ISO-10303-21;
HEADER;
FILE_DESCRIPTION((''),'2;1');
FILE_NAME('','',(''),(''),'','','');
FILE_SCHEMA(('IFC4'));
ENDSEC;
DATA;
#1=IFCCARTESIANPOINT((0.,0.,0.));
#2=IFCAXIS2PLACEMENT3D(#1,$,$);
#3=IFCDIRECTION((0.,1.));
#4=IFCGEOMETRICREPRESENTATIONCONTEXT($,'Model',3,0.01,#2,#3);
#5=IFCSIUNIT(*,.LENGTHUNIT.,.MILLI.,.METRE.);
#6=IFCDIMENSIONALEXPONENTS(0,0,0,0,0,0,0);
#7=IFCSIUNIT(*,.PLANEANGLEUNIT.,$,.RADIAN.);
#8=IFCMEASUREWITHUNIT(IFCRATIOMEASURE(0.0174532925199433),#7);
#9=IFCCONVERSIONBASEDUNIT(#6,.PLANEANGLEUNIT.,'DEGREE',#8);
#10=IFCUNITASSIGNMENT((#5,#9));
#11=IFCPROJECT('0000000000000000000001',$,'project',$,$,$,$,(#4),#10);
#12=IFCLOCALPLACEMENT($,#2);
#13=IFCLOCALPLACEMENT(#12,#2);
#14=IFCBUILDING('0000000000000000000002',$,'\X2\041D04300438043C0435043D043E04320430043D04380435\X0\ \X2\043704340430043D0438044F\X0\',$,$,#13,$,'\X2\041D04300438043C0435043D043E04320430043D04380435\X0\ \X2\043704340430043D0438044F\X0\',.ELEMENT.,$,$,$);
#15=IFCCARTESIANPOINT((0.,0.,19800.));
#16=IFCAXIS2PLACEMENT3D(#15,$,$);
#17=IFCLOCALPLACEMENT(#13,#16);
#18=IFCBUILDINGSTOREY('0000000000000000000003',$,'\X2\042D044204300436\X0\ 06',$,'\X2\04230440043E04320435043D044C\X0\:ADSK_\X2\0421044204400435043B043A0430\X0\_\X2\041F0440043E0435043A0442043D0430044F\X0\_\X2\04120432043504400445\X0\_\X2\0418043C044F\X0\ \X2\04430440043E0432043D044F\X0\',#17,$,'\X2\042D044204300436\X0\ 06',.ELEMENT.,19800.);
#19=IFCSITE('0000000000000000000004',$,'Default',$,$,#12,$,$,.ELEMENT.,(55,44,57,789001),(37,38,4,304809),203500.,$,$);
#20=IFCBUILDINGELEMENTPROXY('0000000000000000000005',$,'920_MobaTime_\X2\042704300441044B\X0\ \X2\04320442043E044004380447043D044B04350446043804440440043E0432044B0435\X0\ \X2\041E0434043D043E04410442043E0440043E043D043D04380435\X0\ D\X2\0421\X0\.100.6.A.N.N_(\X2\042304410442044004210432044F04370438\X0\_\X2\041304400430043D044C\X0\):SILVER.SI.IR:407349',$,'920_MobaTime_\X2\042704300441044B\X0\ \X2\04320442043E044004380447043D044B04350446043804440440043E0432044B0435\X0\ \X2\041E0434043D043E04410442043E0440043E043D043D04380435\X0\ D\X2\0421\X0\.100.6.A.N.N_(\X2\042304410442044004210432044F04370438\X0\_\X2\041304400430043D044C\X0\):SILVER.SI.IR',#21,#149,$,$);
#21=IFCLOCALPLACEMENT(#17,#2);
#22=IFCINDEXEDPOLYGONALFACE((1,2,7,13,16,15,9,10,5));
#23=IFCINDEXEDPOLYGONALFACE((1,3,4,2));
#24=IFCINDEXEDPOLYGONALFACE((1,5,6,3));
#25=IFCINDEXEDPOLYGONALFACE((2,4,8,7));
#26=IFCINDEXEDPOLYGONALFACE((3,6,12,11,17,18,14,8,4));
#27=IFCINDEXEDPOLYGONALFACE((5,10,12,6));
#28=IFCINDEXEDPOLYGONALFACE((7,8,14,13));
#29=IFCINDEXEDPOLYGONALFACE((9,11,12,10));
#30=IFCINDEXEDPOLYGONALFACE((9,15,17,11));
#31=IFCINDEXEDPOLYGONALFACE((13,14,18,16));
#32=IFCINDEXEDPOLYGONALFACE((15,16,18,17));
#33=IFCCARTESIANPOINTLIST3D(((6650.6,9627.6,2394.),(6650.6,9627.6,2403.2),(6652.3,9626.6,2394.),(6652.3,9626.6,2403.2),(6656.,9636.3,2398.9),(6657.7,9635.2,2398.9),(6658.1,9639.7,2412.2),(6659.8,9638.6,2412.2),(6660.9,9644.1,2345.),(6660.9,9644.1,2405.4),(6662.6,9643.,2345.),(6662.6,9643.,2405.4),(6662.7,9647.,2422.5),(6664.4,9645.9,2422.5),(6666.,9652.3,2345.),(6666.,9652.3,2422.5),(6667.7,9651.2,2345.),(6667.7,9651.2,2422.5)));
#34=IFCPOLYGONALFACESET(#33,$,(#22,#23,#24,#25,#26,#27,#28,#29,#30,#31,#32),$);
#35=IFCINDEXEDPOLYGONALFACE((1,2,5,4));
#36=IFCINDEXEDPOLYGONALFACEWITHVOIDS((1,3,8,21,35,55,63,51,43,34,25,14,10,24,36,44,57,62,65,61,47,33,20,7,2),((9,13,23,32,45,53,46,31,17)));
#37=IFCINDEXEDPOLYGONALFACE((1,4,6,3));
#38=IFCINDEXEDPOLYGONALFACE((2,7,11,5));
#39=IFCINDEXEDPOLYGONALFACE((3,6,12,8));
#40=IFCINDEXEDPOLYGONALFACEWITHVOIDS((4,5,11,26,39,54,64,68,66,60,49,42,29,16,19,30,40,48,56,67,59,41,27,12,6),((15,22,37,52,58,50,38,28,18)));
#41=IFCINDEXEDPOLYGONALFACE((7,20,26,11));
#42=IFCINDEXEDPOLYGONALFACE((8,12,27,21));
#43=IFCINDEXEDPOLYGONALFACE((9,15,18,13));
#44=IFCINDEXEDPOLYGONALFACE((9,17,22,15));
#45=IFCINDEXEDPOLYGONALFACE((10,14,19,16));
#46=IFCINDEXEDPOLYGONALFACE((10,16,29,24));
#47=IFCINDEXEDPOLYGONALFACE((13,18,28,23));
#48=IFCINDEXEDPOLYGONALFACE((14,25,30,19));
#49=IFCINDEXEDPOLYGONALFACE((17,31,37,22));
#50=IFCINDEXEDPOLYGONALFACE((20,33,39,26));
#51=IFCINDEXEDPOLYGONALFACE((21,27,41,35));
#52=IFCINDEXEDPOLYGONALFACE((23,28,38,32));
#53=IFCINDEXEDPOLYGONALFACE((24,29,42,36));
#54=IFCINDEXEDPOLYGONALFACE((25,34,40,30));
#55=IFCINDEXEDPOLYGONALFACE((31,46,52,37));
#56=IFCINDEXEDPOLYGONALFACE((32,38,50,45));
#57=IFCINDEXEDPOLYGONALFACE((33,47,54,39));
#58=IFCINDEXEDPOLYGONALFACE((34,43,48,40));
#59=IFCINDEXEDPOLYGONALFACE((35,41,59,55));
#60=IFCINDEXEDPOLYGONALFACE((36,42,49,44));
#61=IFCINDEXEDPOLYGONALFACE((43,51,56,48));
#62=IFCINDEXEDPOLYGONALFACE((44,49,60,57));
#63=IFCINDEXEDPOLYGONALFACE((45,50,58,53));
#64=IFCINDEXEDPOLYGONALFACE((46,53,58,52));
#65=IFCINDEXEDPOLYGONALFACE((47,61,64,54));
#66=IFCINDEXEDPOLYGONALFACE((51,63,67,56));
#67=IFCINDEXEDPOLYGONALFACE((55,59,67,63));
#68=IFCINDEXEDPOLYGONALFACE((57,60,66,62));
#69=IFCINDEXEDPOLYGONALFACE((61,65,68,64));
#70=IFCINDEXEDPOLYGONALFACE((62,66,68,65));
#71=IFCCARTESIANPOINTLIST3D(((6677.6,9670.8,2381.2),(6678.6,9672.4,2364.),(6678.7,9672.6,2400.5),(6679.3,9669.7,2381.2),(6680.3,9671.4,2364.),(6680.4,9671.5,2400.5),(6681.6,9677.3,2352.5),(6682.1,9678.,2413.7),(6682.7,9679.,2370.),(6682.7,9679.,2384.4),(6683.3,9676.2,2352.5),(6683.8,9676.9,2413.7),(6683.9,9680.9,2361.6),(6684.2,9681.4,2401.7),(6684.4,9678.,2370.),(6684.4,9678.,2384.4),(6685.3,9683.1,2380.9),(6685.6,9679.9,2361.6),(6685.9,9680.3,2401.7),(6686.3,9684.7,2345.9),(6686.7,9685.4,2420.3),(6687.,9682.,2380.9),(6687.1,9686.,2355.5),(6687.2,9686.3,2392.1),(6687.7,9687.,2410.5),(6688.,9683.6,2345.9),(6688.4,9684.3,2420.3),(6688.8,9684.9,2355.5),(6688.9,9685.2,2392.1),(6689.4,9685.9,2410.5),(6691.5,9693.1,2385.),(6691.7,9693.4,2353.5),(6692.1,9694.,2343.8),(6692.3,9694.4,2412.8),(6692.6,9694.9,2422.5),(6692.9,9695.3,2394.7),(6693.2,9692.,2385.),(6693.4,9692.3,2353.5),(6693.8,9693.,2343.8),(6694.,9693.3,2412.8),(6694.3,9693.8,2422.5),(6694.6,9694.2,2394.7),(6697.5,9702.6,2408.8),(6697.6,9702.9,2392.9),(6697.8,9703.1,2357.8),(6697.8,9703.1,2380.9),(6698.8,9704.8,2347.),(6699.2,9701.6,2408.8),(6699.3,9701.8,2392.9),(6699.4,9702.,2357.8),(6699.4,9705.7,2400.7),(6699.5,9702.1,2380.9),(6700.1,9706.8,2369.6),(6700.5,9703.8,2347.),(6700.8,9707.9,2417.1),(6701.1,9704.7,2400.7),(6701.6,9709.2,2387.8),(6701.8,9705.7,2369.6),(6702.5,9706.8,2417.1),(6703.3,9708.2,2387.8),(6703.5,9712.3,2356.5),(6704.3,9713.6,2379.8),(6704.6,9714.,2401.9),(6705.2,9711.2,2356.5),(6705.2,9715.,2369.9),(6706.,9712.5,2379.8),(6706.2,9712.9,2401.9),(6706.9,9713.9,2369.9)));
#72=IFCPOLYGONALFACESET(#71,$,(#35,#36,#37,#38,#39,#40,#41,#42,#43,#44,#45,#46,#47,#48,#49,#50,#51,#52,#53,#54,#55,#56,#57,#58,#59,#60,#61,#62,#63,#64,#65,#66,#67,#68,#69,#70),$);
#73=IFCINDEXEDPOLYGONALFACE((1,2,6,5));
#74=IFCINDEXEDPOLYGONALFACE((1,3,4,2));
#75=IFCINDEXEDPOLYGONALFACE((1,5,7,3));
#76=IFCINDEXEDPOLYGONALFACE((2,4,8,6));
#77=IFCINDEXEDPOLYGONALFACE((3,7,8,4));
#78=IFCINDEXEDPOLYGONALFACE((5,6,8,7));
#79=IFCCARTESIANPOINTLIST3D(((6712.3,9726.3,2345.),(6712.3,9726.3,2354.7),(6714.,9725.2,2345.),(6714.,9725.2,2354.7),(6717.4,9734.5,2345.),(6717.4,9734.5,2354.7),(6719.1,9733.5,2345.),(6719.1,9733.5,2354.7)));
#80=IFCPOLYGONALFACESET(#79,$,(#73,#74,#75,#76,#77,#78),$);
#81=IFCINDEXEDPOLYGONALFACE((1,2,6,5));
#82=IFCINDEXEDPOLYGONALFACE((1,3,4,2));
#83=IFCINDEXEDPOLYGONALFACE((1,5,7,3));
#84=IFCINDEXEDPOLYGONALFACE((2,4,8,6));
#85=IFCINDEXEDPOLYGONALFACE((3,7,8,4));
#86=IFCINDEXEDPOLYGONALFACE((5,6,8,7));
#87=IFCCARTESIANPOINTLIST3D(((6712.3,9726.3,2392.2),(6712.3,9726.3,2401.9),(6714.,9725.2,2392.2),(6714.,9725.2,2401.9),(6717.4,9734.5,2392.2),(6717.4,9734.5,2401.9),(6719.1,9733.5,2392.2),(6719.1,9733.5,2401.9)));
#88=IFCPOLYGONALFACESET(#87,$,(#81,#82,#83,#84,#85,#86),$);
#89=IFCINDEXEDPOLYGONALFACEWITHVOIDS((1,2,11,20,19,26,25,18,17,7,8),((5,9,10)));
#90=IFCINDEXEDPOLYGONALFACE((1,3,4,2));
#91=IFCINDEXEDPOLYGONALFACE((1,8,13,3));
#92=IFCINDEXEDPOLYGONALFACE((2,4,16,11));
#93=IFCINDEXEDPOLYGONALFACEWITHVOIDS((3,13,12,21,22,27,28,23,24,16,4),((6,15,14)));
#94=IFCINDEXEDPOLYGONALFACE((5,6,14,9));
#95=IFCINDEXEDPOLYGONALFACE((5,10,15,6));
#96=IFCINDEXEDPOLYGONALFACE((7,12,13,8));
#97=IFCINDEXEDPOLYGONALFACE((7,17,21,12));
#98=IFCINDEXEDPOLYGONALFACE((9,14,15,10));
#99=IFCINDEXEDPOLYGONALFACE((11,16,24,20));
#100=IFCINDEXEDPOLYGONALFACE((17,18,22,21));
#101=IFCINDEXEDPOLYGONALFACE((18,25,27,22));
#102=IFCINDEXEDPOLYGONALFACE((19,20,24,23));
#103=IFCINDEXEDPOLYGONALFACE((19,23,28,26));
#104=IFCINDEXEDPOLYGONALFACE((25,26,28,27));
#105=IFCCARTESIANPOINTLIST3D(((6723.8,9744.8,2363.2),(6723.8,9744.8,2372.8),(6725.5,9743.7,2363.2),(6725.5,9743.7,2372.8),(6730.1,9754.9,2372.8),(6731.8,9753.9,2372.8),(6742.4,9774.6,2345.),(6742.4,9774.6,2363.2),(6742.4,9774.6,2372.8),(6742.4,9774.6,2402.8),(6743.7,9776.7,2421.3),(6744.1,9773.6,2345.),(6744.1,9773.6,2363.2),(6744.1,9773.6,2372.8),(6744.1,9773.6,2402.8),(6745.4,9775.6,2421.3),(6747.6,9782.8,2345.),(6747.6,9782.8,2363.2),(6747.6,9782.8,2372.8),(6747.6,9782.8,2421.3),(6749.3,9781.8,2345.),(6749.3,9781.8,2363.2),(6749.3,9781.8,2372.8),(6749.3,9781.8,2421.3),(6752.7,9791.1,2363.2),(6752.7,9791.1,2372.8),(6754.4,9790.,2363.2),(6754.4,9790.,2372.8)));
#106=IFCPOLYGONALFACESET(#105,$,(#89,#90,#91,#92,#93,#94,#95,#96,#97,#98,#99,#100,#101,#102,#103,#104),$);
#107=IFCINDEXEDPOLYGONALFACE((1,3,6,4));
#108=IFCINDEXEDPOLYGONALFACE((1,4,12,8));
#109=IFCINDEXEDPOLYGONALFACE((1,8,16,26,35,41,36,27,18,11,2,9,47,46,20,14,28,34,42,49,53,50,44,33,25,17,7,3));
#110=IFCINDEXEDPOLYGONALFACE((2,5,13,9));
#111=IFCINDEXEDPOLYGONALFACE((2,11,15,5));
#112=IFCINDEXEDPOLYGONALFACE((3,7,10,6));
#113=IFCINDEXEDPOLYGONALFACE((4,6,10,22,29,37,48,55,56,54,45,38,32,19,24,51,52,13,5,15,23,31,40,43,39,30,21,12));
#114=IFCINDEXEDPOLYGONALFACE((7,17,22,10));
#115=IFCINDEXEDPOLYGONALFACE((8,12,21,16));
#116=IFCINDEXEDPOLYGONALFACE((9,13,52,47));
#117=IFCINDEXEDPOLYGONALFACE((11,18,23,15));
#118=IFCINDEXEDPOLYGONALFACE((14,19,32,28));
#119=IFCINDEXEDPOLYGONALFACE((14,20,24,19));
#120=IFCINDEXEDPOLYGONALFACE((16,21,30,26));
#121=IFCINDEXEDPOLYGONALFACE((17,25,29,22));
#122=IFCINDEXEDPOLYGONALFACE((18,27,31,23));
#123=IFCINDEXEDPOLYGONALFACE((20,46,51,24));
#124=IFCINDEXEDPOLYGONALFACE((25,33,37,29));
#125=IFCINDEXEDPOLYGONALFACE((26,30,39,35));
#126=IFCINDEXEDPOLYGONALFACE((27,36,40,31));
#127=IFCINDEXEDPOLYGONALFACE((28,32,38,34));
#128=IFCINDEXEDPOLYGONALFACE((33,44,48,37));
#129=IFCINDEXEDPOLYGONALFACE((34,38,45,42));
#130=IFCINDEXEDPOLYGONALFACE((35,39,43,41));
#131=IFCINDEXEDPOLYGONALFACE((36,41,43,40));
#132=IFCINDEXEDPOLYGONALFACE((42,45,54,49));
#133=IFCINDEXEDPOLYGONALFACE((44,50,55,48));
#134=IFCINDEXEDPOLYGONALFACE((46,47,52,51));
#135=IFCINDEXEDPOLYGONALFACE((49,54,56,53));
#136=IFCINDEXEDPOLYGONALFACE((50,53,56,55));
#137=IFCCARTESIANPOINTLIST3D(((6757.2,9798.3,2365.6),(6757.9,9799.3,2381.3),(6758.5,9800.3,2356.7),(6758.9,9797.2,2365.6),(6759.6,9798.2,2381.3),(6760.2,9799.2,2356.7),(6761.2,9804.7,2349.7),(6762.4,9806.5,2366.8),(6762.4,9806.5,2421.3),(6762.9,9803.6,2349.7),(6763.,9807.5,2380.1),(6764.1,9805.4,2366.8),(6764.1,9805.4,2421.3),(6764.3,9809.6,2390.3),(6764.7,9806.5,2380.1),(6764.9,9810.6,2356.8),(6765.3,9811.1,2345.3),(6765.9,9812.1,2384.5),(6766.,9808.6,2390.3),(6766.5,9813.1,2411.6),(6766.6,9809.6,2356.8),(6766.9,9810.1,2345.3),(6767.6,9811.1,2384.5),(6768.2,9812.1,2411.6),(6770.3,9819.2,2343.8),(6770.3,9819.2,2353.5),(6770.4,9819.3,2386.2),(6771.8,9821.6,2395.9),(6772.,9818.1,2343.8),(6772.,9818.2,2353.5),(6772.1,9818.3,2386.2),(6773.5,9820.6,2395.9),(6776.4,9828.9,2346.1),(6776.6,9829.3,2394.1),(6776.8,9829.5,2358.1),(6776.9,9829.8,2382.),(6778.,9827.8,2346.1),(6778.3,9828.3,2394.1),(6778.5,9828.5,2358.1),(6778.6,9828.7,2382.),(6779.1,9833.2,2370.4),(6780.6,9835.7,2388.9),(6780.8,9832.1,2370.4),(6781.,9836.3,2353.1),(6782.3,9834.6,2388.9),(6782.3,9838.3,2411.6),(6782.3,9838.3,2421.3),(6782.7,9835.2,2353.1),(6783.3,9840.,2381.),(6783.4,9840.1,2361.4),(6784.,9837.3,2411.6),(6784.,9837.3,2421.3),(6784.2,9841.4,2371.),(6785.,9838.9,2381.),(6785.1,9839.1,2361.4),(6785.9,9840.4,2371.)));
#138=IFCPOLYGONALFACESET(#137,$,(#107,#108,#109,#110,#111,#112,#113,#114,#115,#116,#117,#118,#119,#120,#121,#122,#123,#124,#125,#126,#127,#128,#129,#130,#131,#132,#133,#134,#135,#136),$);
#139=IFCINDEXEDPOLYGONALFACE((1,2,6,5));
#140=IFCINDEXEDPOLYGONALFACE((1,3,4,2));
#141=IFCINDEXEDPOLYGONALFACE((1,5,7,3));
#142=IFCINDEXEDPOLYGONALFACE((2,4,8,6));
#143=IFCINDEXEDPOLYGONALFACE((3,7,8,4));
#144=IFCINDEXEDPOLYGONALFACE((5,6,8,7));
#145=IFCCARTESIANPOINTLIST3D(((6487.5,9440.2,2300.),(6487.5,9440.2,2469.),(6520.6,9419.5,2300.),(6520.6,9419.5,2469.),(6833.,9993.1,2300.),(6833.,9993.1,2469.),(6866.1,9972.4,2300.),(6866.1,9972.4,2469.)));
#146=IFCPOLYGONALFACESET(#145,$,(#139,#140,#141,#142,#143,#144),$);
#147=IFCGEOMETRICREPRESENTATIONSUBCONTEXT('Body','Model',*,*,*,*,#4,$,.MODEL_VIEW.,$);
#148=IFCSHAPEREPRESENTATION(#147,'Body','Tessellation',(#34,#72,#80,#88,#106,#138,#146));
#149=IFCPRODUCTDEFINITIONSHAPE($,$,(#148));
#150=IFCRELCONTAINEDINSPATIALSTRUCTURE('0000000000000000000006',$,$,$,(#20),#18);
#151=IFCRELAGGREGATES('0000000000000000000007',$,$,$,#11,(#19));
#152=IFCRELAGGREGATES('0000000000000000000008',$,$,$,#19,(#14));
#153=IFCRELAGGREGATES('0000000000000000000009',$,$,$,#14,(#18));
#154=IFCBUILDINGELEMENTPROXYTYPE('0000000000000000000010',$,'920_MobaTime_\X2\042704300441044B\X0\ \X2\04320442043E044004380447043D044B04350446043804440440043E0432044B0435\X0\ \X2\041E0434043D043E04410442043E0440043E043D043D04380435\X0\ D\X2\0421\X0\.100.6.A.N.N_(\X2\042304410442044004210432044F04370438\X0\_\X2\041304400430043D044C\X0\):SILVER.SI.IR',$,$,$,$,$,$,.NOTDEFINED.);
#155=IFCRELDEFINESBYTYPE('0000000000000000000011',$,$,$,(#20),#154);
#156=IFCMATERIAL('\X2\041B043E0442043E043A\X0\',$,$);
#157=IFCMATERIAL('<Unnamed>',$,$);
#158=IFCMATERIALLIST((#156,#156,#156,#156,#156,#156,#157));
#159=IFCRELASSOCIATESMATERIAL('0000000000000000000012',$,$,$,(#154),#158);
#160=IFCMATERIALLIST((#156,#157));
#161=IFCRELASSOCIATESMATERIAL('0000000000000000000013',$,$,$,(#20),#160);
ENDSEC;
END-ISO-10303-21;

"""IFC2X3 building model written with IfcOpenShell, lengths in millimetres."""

from ifc_helpers import new_model, entity, si_unit, converted_unit, direction, frame, origin, origin_2d_with_axis, place, context, subcontext, project, spatial, polyline, rectangle, outline, extrude, source, transform, mapped, material, material_list, type_object, type_shapes, element, save


model = new_model("IFC2X3")

# Units and contexts
model_context = context("Model", 3, precision=0.01, world=origin(), true_north=direction((0.0, 1.0)))
body_context = subcontext(model_context, "Body", "Model", "MODEL_VIEW")
ifc_project = project(units=[si_unit("LENGTHUNIT", "METRE", prefix="MILLI"), converted_unit("PLANEANGLEUNIT", "DEGREE", entity("IfcRatioMeasure", 0.0174532925199433), si_unit("PLANEANGLEUNIT", "RADIAN"), dimensions=[0, 0, 0, 0, 0, 0, 0])], contexts=[model_context])

# Site, building, storey
site_placement = place(None, frame((0.0, 0.0, 0.0)))
site = spatial("IfcSite", under=ifc_project, at=site_placement, Name="Default", CompositionType="ELEMENT", RefLatitude=(55, 44, 57, 789001), RefLongitude=(37, 38, 4, 304809), RefElevation=203500.0)
building_placement = place(site_placement, origin())
building = spatial("IfcBuilding", under=site, at=building_placement, Name="Наименование здания", LongName="Наименование здания", CompositionType="ELEMENT")
storey_placement = place(building_placement, frame((0.0, 0.0, 19800.0)))
storey = spatial("IfcBuildingStorey", under=building, at=storey_placement, Name="Этаж 06", ObjectType="Уровень:ADSK_Стрелка_Проектная_Вверх_Имя уровня", LongName="Этаж 06", CompositionType="ELEMENT", Elevation=19800.0)

# Building element proxy
ifc_material_1 = material(Name="Лоток")
ifc_material_2 = material(Name="<Unnamed>")
ifc_material_list_1 = material_list([ifc_material_1, ifc_material_2])
ifc_material_list_2 = material_list([ifc_material_1, ifc_material_1, ifc_material_1, ifc_material_1, ifc_material_1, ifc_material_1, ifc_material_2])
building_element_proxy_type_1 = type_object("IfcBuildingElementProxyType", Name="920_MobaTime_Часы вторичныецифровые Односторонние DС.100.6.A.N.N_(УстрСвязи_Грань):SILVER.SI.IR", PredefinedType="NOTDEFINED", material=ifc_material_list_2)
shared_shape_1 = source(origin(), body_context, "Body", "SweptSolid", [
    extrude(outline(polyline([(-49.3, -13.1), (28.2, -13.1), (28.2, -6.8), (17.9, 1.8), (8.9, 16.0), (-0.3, 16.0), (4.6, 5.8), (11.1, -3.4), (-49.3, -3.4), (-49.3, -13.1)])), frame((-64.6, 9.8, 39.0), z_axis=(0.0, 0.0, 1.0), x_axis=(0.0, 1.0, 0.0)), (0.0, 0.0, 1.0), 2.0),
    extrude(outline(polyline([(2.2, -27.6), (19.0, -27.6), (30.5, -16.1), (33.3, -4.9), (31.0, 5.8), (21.8, 17.2), (5.2, 27.3), (-11.1, 33.0), (-24.0, 32.7), (-33.6, 27.6), (-40.3, 18.6), (-42.8, 5.7), (-38.0, -6.3), (-27.2, -15.0), (-17.5, -17.7), (-8.2, -16.4), (-0.3, -11.9), (5.1, -4.5), (7.3, 6.2), (4.0, 17.2), (18.5, 7.3), (23.6, -2.4), (22.0, -11.4), (14.2, -18.4), (5.3, -18.3), (2.2, -27.6)]), holes=[polyline([(-9.0, 23.3), (-1.3, 14.4), (-2.6, 2.0), (-11.4, -7.0), (-23.4, -6.1), (-32.2, 2.9), (-31.2, 15.1), (-25.6, 22.1), (-17.5, 24.9), (-9.0, 23.3)])]), frame((-2.7, 3.6, 39.0), z_axis=(0.0, 0.0, 1.0), x_axis=(-0.427649, 0.903945, 0.0)), (0.0, 0.0, 1.0), 2.0),
    extrude(rectangle(XDim=9.7, YDim=9.7, at=origin_2d_with_axis()), frame((40.6, -34.7, 39.0)), (0.0, 0.0, 1.0), 2.0),
    extrude(rectangle(XDim=9.7, YDim=9.7, at=origin_2d_with_axis()), frame((40.6, 12.6, 39.0)), (0.0, 0.0, 1.0), 2.0),
    extrude(outline(polyline([(-0.9, -28.1), (8.8, -28.1), (8.8, -9.9), (18.5, -9.9), (18.5, -0.2), (8.8, -0.2), (8.8, 48.3), (1.5, 48.3), (-36.0, -0.2), (-36.0, -9.9), (-0.9, -9.9), (-0.9, -28.1)]), holes=[polyline([(-0.9, -0.2), (-24.1, -0.2), (-0.9, 29.7), (-0.9, -0.2)])]), frame((93.6, -11.4, 39.0)), (0.0, 0.0, 1.0), 2.0),
    extrude(outline(polyline([(3.3, -28.3), (12.5, -28.3), (20.5, -25.0), (26.8, -18.8), (30.7, -10.0), (31.4, 1.6), (26.9, 11.8), (20.1, 18.4), (11.1, 22.3), (1.0, 23.3), (-7.9, 20.4), (-14.9, 14.5), (-18.9, 6.2), (-17.1, -9.0), (-36.7, 0.5), (-29.1, 29.3), (-38.5, 31.7), (-48.1, -4.6), (-11.6, -23.0), (-8.0, -14.0), (-10.8, -7.6), (-10.2, 1.1), (-3.0, 11.8), (9.2, 12.8), (20.0, 5.4), (21.3, -7.5), (15.5, -16.4), (4.6, -18.6), (3.3, -28.3)])), frame((147.1, -8.5, 39.0), z_axis=(0.0, 0.0, 1.0), x_axis=(0.256974, -0.966418, 0.0)), (0.0, 0.0, 1.0), 2.0),
    extrude(rectangle(XDim=652.0, YDim=169.0, at=origin_2d_with_axis()), frame((0.0, 0.0, 0.0), z_axis=(0.0, 0.0, 1.0), x_axis=(-1.0, 0.0, 0.0)), (0.0, 0.0, 1.0), 39.0),
])
type_shapes(building_element_proxy_type_1, [shared_shape_1])
proxy_1_placement = place(storey_placement, frame((6660.2, 9716.6, 2384.5), z_axis=(0.848048, -0.529919, 0.0), x_axis=(0.529919, 0.848048, 0.0)))
element("IfcBuildingElementProxy", 1, at=proxy_1_placement, inside=storey, type_object=building_element_proxy_type_1, material=ifc_material_list_1, Name="920_MobaTime_Часы вторичныецифровые Односторонние DС.100.6.A.N.N_(УстрСвязи_Грань):SILVER.SI.IR:407349", ObjectType="920_MobaTime_Часы вторичныецифровые Односторонние DС.100.6.A.N.N_(УстрСвязи_Грань):SILVER.SI.IR", context=body_context, shape_type="MappedRepresentation", body=[
    mapped(shared_shape_1, transform((0.0, 0.0, 0.0), scale=1.0)),
])

save(model, "model.ifc")
